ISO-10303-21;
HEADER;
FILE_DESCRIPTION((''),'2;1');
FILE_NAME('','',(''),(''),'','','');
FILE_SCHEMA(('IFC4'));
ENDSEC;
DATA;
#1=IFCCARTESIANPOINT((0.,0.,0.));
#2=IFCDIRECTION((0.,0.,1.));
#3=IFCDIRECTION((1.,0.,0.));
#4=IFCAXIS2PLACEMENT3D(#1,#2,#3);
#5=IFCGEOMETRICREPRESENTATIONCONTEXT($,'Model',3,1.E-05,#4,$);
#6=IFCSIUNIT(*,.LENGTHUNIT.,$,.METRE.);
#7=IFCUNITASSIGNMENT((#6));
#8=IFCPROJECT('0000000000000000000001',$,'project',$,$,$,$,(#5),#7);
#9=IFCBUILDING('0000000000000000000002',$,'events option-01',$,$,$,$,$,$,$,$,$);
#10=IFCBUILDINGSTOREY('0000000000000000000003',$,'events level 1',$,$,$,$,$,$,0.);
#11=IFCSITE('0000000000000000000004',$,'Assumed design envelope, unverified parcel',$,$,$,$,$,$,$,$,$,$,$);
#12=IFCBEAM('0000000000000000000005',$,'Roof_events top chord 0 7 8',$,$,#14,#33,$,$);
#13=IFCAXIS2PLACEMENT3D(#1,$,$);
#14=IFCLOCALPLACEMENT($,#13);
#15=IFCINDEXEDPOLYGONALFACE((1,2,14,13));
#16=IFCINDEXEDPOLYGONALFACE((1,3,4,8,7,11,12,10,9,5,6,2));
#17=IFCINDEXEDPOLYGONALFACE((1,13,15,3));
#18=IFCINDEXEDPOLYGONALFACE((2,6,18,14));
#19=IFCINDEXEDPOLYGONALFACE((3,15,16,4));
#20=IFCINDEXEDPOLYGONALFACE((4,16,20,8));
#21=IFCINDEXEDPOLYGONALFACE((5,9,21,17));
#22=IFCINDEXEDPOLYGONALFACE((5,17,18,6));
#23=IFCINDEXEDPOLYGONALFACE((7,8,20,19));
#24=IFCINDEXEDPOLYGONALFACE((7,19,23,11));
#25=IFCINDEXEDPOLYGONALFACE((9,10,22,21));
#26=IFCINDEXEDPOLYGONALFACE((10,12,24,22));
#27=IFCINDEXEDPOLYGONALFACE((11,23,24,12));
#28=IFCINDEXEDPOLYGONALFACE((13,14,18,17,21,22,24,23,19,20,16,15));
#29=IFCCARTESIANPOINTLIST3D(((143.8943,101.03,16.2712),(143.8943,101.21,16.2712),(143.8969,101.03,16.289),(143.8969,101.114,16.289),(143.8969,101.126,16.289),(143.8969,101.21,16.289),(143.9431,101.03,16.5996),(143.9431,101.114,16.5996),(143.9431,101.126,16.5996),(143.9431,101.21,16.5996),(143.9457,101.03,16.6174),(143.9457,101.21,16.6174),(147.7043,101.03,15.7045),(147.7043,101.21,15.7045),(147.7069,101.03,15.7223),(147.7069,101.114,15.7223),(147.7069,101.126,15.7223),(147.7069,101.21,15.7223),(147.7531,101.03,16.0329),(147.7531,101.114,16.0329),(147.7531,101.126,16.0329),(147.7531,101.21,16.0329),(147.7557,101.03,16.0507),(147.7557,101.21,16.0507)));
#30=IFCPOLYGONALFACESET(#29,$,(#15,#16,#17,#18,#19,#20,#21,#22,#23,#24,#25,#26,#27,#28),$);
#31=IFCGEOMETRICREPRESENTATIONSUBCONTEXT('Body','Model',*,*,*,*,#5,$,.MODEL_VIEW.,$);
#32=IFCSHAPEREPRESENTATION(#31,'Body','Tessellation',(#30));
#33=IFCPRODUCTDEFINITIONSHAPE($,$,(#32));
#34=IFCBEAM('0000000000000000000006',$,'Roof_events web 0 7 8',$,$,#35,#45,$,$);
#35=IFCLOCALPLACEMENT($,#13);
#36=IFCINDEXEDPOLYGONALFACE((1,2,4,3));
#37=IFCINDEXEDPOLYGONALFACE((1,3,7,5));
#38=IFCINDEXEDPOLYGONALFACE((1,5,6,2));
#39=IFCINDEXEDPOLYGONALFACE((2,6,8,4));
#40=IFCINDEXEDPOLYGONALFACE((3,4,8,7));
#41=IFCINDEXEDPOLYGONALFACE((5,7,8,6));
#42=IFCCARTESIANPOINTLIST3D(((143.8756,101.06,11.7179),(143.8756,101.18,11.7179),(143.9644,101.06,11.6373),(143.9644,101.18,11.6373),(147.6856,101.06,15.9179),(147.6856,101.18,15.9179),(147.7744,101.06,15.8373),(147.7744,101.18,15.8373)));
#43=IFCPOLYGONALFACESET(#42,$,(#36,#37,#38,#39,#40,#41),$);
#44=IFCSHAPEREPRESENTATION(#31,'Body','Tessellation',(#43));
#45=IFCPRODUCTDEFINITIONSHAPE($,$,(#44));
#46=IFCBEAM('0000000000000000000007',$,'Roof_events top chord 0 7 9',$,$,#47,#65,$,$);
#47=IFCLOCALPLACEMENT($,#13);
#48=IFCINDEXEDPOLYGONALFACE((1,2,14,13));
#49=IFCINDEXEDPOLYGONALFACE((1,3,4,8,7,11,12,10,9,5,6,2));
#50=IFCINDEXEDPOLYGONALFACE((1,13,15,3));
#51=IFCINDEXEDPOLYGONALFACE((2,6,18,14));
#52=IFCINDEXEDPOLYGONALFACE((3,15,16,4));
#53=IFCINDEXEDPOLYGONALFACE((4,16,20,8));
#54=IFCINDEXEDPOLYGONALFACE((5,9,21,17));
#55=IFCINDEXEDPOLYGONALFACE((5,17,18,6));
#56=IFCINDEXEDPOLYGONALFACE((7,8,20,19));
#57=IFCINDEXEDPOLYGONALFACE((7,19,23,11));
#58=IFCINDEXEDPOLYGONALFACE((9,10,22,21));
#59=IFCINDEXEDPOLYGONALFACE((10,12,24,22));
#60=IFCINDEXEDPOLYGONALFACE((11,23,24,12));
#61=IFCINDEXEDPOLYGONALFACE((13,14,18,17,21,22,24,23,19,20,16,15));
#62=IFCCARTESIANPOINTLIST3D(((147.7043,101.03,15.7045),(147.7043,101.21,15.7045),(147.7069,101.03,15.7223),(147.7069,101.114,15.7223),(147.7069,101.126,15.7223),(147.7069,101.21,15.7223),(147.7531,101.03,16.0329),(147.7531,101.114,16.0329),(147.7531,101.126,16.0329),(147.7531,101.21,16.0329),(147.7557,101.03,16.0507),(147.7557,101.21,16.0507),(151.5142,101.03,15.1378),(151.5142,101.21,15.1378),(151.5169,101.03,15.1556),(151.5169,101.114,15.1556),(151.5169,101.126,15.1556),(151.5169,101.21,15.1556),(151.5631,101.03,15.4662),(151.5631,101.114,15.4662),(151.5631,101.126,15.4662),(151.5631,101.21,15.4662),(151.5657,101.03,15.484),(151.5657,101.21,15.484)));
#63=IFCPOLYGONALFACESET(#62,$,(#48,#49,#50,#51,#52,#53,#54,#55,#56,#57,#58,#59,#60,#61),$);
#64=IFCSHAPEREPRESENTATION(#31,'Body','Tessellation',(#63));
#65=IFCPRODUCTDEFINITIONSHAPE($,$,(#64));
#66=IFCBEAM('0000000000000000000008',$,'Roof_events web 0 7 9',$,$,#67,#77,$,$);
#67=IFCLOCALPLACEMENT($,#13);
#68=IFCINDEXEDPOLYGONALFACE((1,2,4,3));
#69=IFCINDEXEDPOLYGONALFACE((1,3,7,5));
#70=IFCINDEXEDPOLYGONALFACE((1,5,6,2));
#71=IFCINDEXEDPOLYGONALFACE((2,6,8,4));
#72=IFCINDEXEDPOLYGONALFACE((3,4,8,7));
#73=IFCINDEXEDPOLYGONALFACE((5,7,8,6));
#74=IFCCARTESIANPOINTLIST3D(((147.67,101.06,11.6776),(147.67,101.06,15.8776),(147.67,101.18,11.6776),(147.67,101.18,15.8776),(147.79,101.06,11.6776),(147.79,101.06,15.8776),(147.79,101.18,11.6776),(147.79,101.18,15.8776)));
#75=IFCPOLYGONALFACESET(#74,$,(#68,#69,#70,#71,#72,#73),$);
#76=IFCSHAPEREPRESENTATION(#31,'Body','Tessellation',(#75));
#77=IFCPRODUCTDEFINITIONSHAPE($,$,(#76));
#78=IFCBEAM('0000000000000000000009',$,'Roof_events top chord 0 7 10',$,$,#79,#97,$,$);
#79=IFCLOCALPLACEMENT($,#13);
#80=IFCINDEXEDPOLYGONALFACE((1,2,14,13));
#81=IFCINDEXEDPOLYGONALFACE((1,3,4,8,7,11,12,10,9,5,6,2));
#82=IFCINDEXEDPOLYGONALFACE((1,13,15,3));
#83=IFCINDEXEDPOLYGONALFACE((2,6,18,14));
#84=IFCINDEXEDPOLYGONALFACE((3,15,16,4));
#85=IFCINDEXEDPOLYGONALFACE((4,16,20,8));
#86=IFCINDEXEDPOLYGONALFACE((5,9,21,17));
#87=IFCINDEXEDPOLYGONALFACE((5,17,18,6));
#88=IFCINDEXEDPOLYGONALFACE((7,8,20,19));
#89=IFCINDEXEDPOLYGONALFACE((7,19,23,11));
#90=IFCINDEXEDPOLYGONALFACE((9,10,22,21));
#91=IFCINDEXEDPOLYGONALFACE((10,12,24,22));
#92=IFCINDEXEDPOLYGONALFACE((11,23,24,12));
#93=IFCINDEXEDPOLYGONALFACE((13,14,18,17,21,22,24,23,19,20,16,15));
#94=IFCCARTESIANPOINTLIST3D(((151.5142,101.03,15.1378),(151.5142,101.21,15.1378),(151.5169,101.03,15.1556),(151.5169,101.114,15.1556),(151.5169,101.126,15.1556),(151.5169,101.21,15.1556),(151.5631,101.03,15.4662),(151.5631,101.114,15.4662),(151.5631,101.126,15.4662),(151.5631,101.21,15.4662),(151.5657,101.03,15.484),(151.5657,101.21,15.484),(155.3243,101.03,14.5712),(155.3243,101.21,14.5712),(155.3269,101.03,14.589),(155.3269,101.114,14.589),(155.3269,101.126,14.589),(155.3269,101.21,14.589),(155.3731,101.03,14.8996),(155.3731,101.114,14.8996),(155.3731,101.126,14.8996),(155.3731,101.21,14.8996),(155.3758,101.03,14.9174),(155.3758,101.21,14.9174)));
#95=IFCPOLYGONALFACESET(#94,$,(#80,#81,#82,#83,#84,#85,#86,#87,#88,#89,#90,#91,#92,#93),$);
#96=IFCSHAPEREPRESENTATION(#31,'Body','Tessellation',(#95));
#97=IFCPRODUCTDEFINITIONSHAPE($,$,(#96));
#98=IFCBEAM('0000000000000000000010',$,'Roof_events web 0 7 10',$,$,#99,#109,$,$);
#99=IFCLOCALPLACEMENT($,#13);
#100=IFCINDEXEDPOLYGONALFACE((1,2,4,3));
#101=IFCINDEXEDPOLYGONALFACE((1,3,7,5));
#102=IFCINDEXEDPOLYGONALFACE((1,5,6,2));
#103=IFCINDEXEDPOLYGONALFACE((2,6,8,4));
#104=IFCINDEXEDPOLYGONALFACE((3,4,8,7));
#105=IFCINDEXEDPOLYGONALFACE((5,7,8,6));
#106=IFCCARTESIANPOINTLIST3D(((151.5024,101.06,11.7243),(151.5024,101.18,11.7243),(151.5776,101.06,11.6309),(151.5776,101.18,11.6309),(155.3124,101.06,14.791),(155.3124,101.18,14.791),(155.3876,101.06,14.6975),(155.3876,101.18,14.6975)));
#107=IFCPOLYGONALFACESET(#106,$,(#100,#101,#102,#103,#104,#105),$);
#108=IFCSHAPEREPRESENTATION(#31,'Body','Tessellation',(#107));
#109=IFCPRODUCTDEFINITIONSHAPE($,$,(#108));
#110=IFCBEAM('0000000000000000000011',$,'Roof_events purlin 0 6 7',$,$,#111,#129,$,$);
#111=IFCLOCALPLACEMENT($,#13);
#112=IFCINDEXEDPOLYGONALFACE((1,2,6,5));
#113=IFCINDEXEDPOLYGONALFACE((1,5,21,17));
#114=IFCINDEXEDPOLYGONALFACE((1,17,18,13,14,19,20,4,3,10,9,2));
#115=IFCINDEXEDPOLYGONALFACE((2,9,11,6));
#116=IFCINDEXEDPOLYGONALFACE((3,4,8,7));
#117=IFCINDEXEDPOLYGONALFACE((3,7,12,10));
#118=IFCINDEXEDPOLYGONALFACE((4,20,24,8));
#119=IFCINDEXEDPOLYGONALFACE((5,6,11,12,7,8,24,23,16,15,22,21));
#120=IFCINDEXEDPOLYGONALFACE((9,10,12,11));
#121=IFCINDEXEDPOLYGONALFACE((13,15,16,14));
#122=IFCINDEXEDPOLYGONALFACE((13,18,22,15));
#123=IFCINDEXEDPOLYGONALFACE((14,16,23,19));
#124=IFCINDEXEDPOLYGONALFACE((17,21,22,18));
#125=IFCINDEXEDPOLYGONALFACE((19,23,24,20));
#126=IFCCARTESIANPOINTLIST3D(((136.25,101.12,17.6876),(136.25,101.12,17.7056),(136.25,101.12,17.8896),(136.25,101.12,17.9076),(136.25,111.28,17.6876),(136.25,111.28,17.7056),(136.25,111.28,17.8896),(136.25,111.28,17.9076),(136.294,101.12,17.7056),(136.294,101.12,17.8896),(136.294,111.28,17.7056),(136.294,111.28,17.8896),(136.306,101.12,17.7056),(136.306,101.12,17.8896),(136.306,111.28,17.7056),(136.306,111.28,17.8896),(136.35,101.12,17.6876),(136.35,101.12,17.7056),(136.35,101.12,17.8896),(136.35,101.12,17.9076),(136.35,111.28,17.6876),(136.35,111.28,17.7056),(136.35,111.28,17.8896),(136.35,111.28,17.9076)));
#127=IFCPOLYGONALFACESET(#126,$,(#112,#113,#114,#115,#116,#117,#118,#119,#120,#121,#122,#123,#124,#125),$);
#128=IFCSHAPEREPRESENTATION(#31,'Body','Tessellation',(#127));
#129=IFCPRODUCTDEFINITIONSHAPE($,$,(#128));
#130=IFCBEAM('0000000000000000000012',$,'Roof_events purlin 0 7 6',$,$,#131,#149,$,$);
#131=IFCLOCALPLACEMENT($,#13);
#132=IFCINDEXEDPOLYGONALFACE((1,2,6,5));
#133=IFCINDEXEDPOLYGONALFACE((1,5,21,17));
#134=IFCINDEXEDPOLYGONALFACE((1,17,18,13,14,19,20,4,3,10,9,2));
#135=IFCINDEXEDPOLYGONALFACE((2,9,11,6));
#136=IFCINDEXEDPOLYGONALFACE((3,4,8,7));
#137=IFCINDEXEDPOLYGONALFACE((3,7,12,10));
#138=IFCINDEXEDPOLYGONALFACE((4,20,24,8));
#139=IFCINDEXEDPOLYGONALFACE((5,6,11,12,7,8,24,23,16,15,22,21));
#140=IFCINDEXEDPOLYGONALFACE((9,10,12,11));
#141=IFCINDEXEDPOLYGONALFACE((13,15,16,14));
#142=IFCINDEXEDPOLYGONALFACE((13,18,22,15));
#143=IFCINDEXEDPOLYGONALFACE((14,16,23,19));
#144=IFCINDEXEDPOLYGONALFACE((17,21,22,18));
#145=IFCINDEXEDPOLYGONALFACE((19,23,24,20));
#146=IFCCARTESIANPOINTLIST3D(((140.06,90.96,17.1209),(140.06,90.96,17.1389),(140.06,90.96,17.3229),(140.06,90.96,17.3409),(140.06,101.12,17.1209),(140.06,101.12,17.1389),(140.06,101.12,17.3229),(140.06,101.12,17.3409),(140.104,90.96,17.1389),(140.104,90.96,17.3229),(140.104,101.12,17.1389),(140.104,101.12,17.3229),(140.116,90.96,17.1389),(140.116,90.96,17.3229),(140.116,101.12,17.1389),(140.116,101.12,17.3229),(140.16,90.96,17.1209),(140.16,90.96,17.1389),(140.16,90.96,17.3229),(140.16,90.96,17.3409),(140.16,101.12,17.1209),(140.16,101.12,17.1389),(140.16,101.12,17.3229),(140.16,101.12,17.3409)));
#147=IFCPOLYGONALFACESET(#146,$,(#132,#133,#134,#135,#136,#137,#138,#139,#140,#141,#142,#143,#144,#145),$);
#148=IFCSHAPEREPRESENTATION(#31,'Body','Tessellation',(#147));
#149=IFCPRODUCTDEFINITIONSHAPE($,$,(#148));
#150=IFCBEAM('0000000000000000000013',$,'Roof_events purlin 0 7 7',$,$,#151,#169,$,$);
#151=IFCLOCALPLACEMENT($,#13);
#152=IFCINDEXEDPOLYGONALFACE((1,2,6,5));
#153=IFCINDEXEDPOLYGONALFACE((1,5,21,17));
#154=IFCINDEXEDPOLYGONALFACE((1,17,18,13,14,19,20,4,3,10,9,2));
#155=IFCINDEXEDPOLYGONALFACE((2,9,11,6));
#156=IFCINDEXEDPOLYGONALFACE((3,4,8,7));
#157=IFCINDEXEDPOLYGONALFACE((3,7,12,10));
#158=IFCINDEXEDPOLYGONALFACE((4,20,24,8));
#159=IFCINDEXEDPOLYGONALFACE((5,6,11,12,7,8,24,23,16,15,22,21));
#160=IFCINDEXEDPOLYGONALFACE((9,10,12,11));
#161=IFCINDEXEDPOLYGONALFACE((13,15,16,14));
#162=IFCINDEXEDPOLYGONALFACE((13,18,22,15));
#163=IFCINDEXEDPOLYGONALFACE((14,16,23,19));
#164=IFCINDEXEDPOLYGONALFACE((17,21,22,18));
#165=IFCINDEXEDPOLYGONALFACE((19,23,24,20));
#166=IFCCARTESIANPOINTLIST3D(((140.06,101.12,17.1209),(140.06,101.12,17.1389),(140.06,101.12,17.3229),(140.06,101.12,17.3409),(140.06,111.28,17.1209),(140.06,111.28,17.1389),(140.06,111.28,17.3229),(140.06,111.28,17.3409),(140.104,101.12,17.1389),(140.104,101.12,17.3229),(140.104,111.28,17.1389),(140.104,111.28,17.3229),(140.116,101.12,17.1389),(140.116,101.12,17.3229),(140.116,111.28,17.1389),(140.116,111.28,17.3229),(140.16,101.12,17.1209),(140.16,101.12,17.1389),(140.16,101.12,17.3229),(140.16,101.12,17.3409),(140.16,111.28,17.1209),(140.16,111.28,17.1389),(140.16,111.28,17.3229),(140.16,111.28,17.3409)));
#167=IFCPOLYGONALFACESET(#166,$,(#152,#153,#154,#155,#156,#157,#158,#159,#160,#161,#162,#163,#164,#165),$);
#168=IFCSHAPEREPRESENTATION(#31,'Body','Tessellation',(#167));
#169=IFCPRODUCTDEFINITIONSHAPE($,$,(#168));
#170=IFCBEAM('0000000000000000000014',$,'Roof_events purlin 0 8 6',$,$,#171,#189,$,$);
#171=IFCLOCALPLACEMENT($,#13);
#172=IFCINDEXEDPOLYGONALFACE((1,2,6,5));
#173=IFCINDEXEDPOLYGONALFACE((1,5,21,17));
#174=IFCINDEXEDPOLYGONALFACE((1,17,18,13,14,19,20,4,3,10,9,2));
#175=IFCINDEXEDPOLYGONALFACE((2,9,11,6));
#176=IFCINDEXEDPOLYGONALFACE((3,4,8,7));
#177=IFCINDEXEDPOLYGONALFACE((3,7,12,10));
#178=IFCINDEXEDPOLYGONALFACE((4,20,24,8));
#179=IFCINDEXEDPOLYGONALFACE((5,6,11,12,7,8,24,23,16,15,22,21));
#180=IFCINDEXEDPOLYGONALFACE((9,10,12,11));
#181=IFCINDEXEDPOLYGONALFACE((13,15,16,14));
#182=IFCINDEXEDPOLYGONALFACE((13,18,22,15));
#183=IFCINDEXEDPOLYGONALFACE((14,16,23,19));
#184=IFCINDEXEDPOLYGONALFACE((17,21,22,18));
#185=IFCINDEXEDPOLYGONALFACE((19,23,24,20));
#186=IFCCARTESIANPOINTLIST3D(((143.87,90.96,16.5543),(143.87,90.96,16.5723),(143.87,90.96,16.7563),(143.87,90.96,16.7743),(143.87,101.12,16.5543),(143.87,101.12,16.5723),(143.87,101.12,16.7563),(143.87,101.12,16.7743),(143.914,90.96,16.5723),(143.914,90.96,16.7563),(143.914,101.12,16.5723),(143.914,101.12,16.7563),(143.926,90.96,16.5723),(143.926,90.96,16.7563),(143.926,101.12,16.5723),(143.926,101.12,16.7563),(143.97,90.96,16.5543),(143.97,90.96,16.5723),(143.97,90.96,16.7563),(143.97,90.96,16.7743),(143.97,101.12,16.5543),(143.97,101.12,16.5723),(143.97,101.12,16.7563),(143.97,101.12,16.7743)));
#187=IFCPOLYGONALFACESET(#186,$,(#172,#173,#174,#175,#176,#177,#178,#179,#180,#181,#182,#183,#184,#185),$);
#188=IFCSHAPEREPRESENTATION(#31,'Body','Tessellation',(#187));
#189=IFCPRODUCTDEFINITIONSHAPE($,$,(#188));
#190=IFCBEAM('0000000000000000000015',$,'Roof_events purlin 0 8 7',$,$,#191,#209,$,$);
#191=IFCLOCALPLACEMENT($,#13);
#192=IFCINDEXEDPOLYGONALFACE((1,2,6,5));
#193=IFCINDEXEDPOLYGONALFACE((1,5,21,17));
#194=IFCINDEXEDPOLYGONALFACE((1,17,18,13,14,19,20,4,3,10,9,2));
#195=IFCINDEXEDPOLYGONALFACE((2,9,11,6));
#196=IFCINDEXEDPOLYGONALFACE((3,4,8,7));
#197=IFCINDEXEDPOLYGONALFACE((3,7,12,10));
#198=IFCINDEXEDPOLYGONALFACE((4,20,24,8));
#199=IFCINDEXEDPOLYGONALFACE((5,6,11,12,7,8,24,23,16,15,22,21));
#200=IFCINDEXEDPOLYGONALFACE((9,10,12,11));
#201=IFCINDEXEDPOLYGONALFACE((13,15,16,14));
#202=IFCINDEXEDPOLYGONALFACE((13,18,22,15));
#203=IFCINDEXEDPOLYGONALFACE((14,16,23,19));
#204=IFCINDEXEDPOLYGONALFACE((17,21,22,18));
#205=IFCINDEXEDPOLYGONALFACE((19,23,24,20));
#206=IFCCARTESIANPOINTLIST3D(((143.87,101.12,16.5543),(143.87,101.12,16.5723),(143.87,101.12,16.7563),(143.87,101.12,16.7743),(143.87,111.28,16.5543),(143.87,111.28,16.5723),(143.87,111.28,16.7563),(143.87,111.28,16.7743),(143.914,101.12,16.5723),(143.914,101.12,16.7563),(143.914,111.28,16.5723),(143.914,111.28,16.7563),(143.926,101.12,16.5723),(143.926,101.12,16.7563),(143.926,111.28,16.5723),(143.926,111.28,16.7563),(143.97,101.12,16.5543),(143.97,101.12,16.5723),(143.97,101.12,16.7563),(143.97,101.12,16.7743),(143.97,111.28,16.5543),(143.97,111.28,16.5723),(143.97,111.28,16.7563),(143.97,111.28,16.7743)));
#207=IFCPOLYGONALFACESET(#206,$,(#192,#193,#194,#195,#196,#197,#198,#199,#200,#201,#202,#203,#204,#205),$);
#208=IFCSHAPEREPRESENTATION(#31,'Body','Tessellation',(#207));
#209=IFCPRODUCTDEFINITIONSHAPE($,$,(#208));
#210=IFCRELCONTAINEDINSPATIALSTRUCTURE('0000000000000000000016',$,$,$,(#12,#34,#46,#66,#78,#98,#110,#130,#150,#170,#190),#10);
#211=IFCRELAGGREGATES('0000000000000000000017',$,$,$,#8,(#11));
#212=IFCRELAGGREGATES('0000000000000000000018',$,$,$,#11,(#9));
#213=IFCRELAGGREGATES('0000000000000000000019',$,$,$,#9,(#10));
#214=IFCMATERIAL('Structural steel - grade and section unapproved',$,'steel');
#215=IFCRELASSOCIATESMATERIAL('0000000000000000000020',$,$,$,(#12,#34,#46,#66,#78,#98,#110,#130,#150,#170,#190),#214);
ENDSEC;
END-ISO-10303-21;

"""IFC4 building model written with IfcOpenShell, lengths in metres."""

from ifc_helpers import new_model, si_unit, frame, origin_with_axes, place, context, subcontext, project, spatial, rectangle, i_section, extrude, material, element, save


model = new_model("IFC4")

# Units and contexts
model_context = context("Model", 3, precision=1e-05, world=origin_with_axes())
body_context = subcontext(model_context, "Body", "Model", "MODEL_VIEW")
ifc_project = project(units=[si_unit("LENGTHUNIT", "METRE")], contexts=[model_context])

# Site, building, storey
site = spatial("IfcSite", under=ifc_project, Name="Assumed design envelope, unverified parcel")
building = spatial("IfcBuilding", under=site, Name="events option-01")
storey = spatial("IfcBuildingStorey", under=building, Name="events level 1", Elevation=0.0)

# Beams
ifc_material = material(Name="Structural steel - grade and section unapproved", Category="steel")
beam_1_placement = place(None, frame((143.92, 101.12, 16.4443), z_axis=(0.98912, 0.0, -0.147113), x_axis=(0.0, 1.0, 0.0)))
element("IfcBeam", 1, at=beam_1_placement, inside=storey, material=ifc_material, Name="Roof_events top chord 0 7 8", context=body_context, shape_type="SweptSolid", body=[
    extrude(i_section(OverallWidth=0.18, OverallDepth=0.35, WebThickness=0.012, FlangeThickness=0.018, FilletRadius=0.0), origin_with_axes(), (0.0, 0.0, 1.0), 3.8519),
])
beam_2_placement = place(None, frame((143.92, 101.12, 11.6776), z_axis=(0.671882, 0.0, 0.740658), x_axis=(0.0, 1.0, 0.0)))
element("IfcBeam", 2, at=beam_2_placement, inside=storey, material=ifc_material, Name="Roof_events web 0 7 8", context=body_context, shape_type="SweptSolid", body=[
    extrude(rectangle(XDim=0.12, YDim=0.12), origin_with_axes(), (0.0, 0.0, 1.0), 5.6706),
])
beam_3_placement = place(None, frame((147.73, 101.12, 15.8776), z_axis=(0.98912, 0.0, -0.147113), x_axis=(0.0, 1.0, 0.0)))
element("IfcBeam", 3, at=beam_3_placement, inside=storey, material=ifc_material, Name="Roof_events top chord 0 7 9", context=body_context, shape_type="SweptSolid", body=[
    extrude(i_section(OverallWidth=0.18, OverallDepth=0.35, WebThickness=0.012, FlangeThickness=0.018, FilletRadius=0.0), origin_with_axes(), (0.0, 0.0, 1.0), 3.8519),
])
beam_4_placement = place(None, frame((147.73, 101.12, 11.6776), z_axis=(0.0, 0.0, 1.0), x_axis=(-1.0, 0.0, 0.0)))
element("IfcBeam", 4, at=beam_4_placement, inside=storey, material=ifc_material, Name="Roof_events web 0 7 9", context=body_context, shape_type="SweptSolid", body=[
    extrude(rectangle(XDim=0.12, YDim=0.12), origin_with_axes(), (0.0, 0.0, 1.0), 4.2),
])
beam_5_placement = place(None, frame((151.54, 101.12, 15.3109), z_axis=(0.98912, 0.0, -0.147113), x_axis=(0.0, 1.0, 0.0)))
element("IfcBeam", 5, at=beam_5_placement, inside=storey, material=ifc_material, Name="Roof_events top chord 0 7 10", context=body_context, shape_type="SweptSolid", body=[
    extrude(i_section(OverallWidth=0.18, OverallDepth=0.35, WebThickness=0.012, FlangeThickness=0.018, FilletRadius=0.0), origin_with_axes(), (0.0, 0.0, 1.0), 3.8519),
])
beam_6_placement = place(None, frame((151.54, 101.12, 11.6776), z_axis=(0.779005, 0.0, 0.627018), x_axis=(0.0, 1.0, 0.0)))
element("IfcBeam", 6, at=beam_6_placement, inside=storey, material=ifc_material, Name="Roof_events web 0 7 10", context=body_context, shape_type="SweptSolid", body=[
    extrude(rectangle(XDim=0.12, YDim=0.12), origin_with_axes(), (0.0, 0.0, 1.0), 4.8909),
])
beam_7_placement = place(None, frame((136.3, 101.12, 17.7976), z_axis=(0.0, 1.0, 0.0), x_axis=(-1.0, 0.0, 0.0)))
element("IfcBeam", 7, at=beam_7_placement, inside=storey, material=ifc_material, Name="Roof_events purlin 0 6 7", context=body_context, shape_type="SweptSolid", body=[
    extrude(i_section(OverallWidth=0.1, OverallDepth=0.22, WebThickness=0.012, FlangeThickness=0.018, FilletRadius=0.0), origin_with_axes(), (0.0, 0.0, 1.0), 10.16),
])
beam_8_placement = place(None, frame((140.11, 90.96, 17.2309), z_axis=(0.0, 1.0, 0.0), x_axis=(-1.0, 0.0, 0.0)))
element("IfcBeam", 8, at=beam_8_placement, inside=storey, material=ifc_material, Name="Roof_events purlin 0 7 6", context=body_context, shape_type="SweptSolid", body=[
    extrude(i_section(OverallWidth=0.1, OverallDepth=0.22, WebThickness=0.012, FlangeThickness=0.018, FilletRadius=0.0), origin_with_axes(), (0.0, 0.0, 1.0), 10.16),
])
beam_9_placement = place(None, frame((140.11, 101.12, 17.2309), z_axis=(0.0, 1.0, 0.0), x_axis=(-1.0, 0.0, 0.0)))
element("IfcBeam", 9, at=beam_9_placement, inside=storey, material=ifc_material, Name="Roof_events purlin 0 7 7", context=body_context, shape_type="SweptSolid", body=[
    extrude(i_section(OverallWidth=0.1, OverallDepth=0.22, WebThickness=0.012, FlangeThickness=0.018, FilletRadius=0.0), origin_with_axes(), (0.0, 0.0, 1.0), 10.16),
])
beam_10_placement = place(None, frame((143.92, 90.96, 16.6643), z_axis=(0.0, 1.0, 0.0), x_axis=(-1.0, 0.0, 0.0)))
element("IfcBeam", 10, at=beam_10_placement, inside=storey, material=ifc_material, Name="Roof_events purlin 0 8 6", context=body_context, shape_type="SweptSolid", body=[
    extrude(i_section(OverallWidth=0.1, OverallDepth=0.22, WebThickness=0.012, FlangeThickness=0.018, FilletRadius=0.0), origin_with_axes(), (0.0, 0.0, 1.0), 10.16),
])
for number, where, z_axis, x_axis, name in (
    (11, (143.92, 101.12, 16.6643), (0.0, 1.0, 0.0), (-1.0, 0.0, 0.0), "Roof_events purlin 0 8 7"),
):
    element("IfcBeam", number, at=place(None, frame(where, z_axis=z_axis, x_axis=x_axis)), inside=storey, material=ifc_material, Name=name, context=body_context, shape_type="SweptSolid", body=[
        extrude(i_section(OverallWidth=0.1, OverallDepth=0.22, WebThickness=0.012, FlangeThickness=0.018, FilletRadius=0.0), origin_with_axes(), (0.0, 0.0, 1.0), 10.16),
    ])

save(model, "model.ifc")
